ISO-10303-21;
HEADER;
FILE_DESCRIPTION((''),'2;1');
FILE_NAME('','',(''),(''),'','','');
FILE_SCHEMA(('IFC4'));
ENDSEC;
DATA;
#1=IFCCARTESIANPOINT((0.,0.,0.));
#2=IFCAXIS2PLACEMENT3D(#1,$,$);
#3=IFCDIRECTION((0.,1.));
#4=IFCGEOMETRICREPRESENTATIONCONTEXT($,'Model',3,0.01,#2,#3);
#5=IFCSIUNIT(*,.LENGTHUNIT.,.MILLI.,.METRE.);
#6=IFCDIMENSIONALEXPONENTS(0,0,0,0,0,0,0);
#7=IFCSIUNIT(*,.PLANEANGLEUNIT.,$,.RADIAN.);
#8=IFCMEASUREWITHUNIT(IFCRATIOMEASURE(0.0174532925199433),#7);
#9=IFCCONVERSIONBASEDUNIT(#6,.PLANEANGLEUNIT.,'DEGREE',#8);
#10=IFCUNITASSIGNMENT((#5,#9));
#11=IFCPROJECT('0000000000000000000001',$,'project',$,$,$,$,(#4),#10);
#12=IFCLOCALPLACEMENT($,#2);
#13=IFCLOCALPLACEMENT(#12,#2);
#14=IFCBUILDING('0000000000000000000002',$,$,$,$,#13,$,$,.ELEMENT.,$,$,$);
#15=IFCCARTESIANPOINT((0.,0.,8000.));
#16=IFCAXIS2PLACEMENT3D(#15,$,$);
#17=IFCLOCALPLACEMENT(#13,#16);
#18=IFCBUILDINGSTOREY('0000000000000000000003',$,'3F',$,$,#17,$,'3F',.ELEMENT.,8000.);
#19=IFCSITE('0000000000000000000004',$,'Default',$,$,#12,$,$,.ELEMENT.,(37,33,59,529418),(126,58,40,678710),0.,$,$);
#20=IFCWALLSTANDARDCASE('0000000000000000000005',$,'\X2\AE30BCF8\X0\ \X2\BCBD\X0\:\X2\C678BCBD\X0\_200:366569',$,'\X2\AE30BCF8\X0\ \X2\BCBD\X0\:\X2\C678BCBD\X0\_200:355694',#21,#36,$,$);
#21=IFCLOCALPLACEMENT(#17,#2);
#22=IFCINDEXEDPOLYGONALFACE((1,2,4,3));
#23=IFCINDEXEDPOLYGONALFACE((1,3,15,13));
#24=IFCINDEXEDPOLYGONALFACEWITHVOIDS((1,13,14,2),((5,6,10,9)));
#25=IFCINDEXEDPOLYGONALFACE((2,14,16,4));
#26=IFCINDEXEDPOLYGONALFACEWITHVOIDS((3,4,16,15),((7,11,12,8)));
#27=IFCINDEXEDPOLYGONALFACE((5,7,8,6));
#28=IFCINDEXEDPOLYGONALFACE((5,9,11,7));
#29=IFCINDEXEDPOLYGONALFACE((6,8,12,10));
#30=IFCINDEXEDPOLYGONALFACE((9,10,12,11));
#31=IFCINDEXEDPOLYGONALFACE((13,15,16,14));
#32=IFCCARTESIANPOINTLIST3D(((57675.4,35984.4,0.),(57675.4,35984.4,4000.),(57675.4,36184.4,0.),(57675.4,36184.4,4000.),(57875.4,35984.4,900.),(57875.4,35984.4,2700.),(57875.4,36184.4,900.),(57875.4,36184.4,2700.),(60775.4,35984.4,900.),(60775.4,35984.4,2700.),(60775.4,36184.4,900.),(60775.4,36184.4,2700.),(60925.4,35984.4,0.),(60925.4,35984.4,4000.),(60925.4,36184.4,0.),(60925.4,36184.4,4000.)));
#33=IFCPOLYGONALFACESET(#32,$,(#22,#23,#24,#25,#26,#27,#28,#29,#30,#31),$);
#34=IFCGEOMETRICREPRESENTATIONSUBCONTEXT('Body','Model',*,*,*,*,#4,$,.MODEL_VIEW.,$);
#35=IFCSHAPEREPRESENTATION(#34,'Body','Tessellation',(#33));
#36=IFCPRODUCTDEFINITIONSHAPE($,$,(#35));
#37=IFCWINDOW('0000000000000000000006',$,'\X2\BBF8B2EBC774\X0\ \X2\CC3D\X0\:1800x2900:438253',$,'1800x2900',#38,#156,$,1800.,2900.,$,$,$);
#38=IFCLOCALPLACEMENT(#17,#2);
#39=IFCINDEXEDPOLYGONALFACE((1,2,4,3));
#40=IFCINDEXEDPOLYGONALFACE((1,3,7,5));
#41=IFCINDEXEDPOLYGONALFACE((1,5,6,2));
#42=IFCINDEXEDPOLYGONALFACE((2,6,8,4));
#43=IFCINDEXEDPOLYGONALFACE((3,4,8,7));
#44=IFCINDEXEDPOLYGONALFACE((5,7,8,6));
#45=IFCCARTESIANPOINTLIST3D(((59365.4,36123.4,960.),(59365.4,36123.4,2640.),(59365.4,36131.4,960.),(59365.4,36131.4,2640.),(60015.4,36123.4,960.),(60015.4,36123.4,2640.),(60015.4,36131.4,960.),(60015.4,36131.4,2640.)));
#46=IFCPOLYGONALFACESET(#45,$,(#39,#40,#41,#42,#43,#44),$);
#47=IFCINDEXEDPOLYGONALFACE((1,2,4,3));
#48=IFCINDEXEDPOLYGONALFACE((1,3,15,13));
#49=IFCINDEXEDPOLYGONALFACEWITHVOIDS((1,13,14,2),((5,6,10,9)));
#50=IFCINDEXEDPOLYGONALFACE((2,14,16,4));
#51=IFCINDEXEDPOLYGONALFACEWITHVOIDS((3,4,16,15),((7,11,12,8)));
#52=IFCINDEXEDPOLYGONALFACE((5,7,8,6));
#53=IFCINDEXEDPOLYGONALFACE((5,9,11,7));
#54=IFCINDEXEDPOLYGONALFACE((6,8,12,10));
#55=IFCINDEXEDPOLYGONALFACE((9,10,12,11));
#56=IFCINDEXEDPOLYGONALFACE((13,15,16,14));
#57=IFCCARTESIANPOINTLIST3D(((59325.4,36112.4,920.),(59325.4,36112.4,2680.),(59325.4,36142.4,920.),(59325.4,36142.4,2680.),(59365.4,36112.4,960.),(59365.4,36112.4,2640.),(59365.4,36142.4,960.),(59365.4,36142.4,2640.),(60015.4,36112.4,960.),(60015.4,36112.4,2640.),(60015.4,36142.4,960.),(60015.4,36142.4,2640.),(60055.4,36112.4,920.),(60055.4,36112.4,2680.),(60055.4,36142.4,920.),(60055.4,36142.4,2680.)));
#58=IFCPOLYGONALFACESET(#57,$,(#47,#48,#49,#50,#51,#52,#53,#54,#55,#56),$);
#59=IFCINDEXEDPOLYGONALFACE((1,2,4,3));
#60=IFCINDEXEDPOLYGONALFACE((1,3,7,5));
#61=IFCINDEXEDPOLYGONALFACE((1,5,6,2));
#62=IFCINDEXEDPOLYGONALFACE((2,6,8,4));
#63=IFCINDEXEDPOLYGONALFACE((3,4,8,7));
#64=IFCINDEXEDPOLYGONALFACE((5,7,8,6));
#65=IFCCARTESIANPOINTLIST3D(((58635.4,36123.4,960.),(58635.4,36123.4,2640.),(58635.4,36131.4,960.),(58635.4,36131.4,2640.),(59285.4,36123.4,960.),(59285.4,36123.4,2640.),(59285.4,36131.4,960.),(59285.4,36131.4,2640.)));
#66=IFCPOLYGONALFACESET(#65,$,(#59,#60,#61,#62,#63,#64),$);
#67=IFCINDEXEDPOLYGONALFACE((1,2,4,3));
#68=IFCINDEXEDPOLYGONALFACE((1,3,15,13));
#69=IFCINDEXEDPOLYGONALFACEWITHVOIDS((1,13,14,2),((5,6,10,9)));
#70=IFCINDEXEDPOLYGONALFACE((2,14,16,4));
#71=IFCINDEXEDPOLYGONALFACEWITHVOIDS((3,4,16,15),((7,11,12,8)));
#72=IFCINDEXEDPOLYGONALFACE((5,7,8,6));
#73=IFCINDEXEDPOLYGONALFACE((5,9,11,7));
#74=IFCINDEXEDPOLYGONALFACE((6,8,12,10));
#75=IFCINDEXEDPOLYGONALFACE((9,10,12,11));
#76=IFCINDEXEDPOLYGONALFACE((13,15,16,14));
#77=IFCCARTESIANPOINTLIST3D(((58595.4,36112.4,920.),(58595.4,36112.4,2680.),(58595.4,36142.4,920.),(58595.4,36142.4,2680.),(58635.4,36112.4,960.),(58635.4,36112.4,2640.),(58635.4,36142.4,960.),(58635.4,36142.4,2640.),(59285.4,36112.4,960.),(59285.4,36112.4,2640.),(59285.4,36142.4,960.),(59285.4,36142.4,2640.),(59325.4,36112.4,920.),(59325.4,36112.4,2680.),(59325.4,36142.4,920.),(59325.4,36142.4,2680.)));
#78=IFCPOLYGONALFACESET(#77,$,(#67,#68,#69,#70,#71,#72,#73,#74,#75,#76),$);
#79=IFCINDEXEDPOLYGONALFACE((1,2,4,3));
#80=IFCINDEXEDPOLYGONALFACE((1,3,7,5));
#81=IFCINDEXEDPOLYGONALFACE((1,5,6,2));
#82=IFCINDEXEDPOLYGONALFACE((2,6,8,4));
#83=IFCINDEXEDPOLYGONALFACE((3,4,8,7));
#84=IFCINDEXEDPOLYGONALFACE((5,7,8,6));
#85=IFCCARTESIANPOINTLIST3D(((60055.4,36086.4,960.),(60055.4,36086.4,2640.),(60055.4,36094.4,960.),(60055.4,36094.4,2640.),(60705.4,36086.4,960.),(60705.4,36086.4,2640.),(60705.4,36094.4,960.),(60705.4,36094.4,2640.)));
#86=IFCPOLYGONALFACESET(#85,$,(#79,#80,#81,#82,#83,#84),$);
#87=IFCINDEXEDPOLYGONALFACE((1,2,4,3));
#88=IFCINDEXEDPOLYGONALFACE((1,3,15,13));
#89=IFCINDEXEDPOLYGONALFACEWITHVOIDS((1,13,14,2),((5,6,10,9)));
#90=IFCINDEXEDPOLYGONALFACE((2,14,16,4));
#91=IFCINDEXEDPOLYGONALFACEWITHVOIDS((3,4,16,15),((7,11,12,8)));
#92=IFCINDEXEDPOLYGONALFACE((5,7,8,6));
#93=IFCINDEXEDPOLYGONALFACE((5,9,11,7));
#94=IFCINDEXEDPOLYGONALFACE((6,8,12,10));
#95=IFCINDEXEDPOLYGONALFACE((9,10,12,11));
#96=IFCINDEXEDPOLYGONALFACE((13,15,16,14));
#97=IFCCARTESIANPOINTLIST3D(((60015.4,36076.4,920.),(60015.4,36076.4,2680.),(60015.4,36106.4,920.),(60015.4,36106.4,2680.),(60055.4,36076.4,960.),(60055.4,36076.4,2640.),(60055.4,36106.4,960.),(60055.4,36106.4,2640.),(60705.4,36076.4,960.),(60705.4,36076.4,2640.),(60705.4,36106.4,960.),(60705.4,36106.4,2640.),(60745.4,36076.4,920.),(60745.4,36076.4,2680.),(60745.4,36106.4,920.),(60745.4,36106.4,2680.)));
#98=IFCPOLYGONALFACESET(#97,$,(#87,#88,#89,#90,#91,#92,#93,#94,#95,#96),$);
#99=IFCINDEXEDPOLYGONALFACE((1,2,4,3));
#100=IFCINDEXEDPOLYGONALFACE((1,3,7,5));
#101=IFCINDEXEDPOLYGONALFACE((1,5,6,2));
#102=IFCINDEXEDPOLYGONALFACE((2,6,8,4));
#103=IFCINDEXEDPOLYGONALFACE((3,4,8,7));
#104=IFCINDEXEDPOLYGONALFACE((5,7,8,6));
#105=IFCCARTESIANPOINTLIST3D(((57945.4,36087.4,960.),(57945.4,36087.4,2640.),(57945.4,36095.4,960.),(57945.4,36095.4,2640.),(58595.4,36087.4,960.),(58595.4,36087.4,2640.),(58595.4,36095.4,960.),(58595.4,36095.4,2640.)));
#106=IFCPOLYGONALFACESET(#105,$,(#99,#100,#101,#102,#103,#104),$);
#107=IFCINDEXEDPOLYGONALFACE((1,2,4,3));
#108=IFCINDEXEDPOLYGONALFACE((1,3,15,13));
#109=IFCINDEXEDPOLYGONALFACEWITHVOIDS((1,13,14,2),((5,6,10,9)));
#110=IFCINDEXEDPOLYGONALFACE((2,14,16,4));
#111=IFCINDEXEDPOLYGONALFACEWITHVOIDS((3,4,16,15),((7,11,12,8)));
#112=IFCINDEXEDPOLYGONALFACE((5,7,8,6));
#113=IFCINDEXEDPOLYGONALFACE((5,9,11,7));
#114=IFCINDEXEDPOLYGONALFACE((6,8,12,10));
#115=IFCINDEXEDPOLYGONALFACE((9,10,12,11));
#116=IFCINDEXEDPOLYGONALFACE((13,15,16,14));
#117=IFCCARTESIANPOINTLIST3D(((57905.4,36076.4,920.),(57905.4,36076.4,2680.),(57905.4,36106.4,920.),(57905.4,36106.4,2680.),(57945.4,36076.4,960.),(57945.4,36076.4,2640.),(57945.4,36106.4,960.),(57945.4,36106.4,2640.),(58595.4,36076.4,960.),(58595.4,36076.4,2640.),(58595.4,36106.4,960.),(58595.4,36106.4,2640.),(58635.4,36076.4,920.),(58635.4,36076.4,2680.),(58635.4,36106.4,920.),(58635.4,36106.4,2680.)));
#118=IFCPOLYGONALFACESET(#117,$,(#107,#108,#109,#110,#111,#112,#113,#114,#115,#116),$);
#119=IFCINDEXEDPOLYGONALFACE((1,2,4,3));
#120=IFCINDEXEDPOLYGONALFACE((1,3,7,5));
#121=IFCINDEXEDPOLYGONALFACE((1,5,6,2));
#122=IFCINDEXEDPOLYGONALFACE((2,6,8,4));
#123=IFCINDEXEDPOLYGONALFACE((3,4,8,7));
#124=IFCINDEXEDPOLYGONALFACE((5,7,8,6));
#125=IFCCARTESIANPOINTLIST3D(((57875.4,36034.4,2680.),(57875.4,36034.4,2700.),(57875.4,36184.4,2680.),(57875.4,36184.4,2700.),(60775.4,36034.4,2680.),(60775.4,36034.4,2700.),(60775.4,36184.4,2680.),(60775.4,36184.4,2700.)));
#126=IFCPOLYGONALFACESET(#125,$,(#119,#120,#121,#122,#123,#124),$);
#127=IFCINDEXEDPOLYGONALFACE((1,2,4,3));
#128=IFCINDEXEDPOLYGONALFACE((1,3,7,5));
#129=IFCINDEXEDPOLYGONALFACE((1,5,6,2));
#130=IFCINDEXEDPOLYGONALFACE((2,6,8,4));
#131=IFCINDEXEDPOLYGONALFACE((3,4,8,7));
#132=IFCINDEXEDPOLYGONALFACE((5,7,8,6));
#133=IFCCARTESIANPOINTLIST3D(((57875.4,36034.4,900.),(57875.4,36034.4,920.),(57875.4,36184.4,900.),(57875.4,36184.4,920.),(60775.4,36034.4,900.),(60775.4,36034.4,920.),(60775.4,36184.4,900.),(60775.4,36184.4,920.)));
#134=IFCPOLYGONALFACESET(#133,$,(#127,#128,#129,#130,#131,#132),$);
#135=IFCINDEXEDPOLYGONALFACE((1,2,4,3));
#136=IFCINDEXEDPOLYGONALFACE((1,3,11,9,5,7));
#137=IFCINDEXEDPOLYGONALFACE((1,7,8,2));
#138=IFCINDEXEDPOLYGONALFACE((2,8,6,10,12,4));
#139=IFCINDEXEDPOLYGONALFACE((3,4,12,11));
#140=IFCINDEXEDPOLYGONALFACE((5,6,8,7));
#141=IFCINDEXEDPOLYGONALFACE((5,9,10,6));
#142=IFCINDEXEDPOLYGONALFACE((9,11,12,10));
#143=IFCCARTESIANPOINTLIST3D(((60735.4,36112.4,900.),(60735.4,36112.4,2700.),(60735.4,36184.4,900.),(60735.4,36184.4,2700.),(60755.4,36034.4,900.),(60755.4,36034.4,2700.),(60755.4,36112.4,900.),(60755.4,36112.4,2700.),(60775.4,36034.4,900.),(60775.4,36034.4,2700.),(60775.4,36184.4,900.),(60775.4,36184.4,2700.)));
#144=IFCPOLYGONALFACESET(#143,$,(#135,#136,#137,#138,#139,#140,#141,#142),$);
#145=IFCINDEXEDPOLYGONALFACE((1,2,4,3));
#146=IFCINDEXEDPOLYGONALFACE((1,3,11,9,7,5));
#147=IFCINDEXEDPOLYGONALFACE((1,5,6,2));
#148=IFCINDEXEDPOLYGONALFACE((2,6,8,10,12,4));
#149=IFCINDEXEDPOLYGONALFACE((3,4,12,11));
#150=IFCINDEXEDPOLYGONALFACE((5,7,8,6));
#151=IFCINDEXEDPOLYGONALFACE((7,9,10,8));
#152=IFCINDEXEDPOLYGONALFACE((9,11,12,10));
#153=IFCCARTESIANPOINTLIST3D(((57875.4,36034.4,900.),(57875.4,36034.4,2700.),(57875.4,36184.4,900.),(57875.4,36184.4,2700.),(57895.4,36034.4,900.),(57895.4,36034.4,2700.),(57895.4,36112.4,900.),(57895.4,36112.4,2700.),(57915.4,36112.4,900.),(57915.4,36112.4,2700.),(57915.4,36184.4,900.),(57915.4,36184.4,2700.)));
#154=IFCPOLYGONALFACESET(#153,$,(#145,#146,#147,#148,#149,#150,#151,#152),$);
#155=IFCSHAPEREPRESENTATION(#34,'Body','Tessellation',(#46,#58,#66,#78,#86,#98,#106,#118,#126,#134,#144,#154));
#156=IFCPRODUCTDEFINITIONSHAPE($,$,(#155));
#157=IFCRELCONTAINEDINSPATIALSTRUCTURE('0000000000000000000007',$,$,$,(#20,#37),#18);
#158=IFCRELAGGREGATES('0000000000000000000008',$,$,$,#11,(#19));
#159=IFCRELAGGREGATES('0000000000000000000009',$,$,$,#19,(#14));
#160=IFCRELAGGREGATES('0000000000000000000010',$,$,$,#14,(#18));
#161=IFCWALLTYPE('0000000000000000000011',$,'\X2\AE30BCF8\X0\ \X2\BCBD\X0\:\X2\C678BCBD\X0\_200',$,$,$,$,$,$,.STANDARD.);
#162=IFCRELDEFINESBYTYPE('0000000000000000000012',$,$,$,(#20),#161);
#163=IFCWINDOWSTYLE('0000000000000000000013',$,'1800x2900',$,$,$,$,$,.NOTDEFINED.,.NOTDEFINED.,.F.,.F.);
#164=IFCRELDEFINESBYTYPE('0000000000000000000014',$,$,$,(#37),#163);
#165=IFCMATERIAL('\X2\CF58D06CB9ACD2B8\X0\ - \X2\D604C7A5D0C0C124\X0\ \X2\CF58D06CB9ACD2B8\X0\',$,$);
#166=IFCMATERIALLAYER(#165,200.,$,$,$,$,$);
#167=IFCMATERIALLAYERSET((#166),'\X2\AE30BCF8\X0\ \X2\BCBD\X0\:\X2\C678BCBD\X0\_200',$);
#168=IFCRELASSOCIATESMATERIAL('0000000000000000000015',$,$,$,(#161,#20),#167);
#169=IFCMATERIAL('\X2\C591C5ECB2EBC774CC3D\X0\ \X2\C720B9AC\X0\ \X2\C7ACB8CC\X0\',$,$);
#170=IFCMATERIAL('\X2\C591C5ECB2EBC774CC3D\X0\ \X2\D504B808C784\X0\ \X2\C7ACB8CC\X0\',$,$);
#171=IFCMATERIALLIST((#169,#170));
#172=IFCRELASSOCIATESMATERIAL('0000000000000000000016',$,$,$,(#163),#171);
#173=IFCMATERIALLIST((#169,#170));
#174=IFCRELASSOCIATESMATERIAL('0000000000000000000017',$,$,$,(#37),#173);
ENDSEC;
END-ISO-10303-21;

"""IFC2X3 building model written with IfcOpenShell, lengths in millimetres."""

from ifc_helpers import new_model, entity, si_unit, converted_unit, direction, frame, frame_2d, origin, origin_2d_with_axis, place, context, subcontext, project, spatial, polyline, rectangle, outline, extrude, source, transform, mapped, material, material_list, layer, layer_set, layer_usage, type_object, type_shapes, element, fill, save


model = new_model("IFC2X3")

# Units and contexts
model_context = context("Model", 3, precision=0.01, world=origin(), true_north=direction((0.0, 1.0)))
body_context = subcontext(model_context, "Body", "Model", "MODEL_VIEW")
ifc_project = project(units=[si_unit("LENGTHUNIT", "METRE", prefix="MILLI"), converted_unit("PLANEANGLEUNIT", "DEGREE", entity("IfcRatioMeasure", 0.0174532925199433), si_unit("PLANEANGLEUNIT", "RADIAN"), dimensions=[0, 0, 0, 0, 0, 0, 0])], contexts=[model_context])

# Site, building, storey
site_placement = place(None, origin())
site = spatial("IfcSite", under=ifc_project, at=site_placement, Name="Default", CompositionType="ELEMENT", RefLatitude=(37, 33, 59, 529418), RefLongitude=(126, 58, 40, 678710), RefElevation=0.0)
building_placement = place(site_placement, origin())
building = spatial("IfcBuilding", under=site, at=building_placement, CompositionType="ELEMENT")
storey_placement = place(building_placement, frame((0.0, 0.0, 8000.0)))
storey = spatial("IfcBuildingStorey", under=building, at=storey_placement, Name="3F", LongName="3F", CompositionType="ELEMENT", Elevation=8000.0)

# Wall, opening, window
ifc_material_1 = material(Name="콘크리트 - 현장타설 콘크리트")
ifc_layer_1 = layer(ifc_material_1, 200.0)
ifc_layer_set_1 = layer_set([ifc_layer_1], Name="기본 벽:외벽_200")
ifc_layer_usage_1 = layer_usage(ifc_layer_set_1, "AXIS2", "NEGATIVE", 100.0)
wall_type_1 = type_object("IfcWallType", Name="기본 벽:외벽_200", PredefinedType="STANDARD", material=ifc_layer_set_1)
wall_1_placement = place(storey_placement, frame((60925.4, 36084.4, 0.0), z_axis=(0.0, 0.0, 1.0), x_axis=(-1.0, 0.0, 0.0)))
wall_1 = element("IfcWallStandardCase", 1, at=wall_1_placement, inside=storey, type_object=wall_type_1, material=ifc_layer_usage_1, Name="기본 벽:외벽_200:366569", ObjectType="기본 벽:외벽_200:355694", context=body_context, shape_type="SweptSolid", body=[
    extrude(rectangle(XDim=3250.0, YDim=200.0, at=frame_2d((1625.0, 0.0), x_axis=(-1.0, 0.0))), origin(), (0.0, 0.0, 1.0), 4000.0),
])
opening_1_placement = place(wall_1_placement, frame((3050.0, 100.0, 900.0)))
opening_1 = element("IfcOpeningElement", 2, at=opening_1_placement, cuts=wall_1, ObjectType="Opening", context=body_context, shape_type="SweptSolid", body=[
    extrude(rectangle(XDim=1800.0, YDim=2900.0, at=frame_2d((900.0, 1450.0), x_axis=(1.0, 0.0))), frame((0.0, 0.0, 0.0), z_axis=(0.0, -1.0, 0.0), x_axis=(0.0, 0.0, 1.0)), (0.0, 0.0, 1.0), 200.0),
])
ifc_material_2 = material(Name="양여닫이창 유리 재료")
ifc_material_3 = material(Name="양여닫이창 프레임 재료")
ifc_material_list_1 = material_list([ifc_material_2, ifc_material_3])
ifc_material_list_2 = material_list([ifc_material_2, ifc_material_3])
window_style = type_object("IfcWindowStyle", Name="1800x2900", ConstructionType="NOTDEFINED", OperationType="NOTDEFINED", ParameterTakesPrecedence=False, Sizeable=False, material=ifc_material_list_2)
shared_shape_1 = source(origin(), body_context, "Body", "SweptSolid", [
    extrude(rectangle(XDim=8.0, YDim=650.0, at=frame_2d((0.0, 0.0), x_axis=(1.0, 0.0))), frame((1815.0, 143.0, 60.0), z_axis=(0.0, 0.0, 1.0), x_axis=(0.0, 1.0, 0.0)), (0.0, 0.0, 1.0), 1680.0),
    extrude(outline(polyline([(-880.0, -365.0), (880.0, -365.0), (880.0, 365.0), (-880.0, 365.0), (-880.0, -365.0)]), holes=[polyline([(840.0, -325.0), (-840.0, -325.0), (-840.0, 325.0), (840.0, 325.0), (840.0, -325.0)])]), frame((1815.0, 128.0, 900.0), z_axis=(0.0, 1.0, 0.0), x_axis=(0.0, 0.0, -1.0)), (0.0, 0.0, 1.0), 30.0),
    extrude(rectangle(XDim=8.0, YDim=650.0, at=frame_2d((0.0, 0.0), x_axis=(1.0, 0.0))), frame((1085.0, 143.0, 60.0), z_axis=(0.0, 0.0, 1.0), x_axis=(0.0, 1.0, 0.0)), (0.0, 0.0, 1.0), 1680.0),
    extrude(outline(polyline([(-880.0, -365.0), (880.0, -365.0), (880.0, 365.0), (-880.0, 365.0), (-880.0, -365.0)]), holes=[polyline([(840.0, -325.0), (-840.0, -325.0), (-840.0, 325.0), (840.0, 325.0), (840.0, -325.0)])]), frame((1085.0, 128.0, 900.0), z_axis=(0.0, 1.0, 0.0), x_axis=(0.0, 0.0, -1.0)), (0.0, 0.0, 1.0), 30.0),
    extrude(rectangle(XDim=8.0, YDim=650.0, at=frame_2d((0.0, 0.0), x_axis=(1.0, 0.0))), frame((2505.0, 106.0, 60.0), z_axis=(0.0, 0.0, 1.0), x_axis=(0.0, 1.0, 0.0)), (0.0, 0.0, 1.0), 1680.0),
    extrude(outline(polyline([(-880.0, -365.0), (880.0, -365.0), (880.0, 365.0), (-880.0, 365.0), (-880.0, -365.0)]), holes=[polyline([(840.0, -325.0), (-840.0, -325.0), (-840.0, 325.0), (840.0, 325.0), (840.0, -325.0)])]), frame((2505.0, 92.0, 900.0), z_axis=(0.0, 1.0, 0.0), x_axis=(0.0, 0.0, -1.0)), (0.0, 0.0, 1.0), 30.0),
    extrude(rectangle(XDim=8.0, YDim=650.0, at=origin_2d_with_axis()), frame((395.0, 107.0, 60.0), z_axis=(0.0, 0.0, 1.0), x_axis=(0.0, 1.0, 0.0)), (0.0, 0.0, 1.0), 1680.0),
    extrude(outline(polyline([(-880.0, -365.0), (880.0, -365.0), (880.0, 365.0), (-880.0, 365.0), (-880.0, -365.0)]), holes=[polyline([(840.0, -325.0), (-840.0, -325.0), (-840.0, 325.0), (840.0, 325.0), (840.0, -325.0)])]), frame((395.0, 92.0, 900.0), z_axis=(0.0, 1.0, 0.0), x_axis=(0.0, 0.0, -1.0)), (0.0, 0.0, 1.0), 30.0),
    extrude(rectangle(XDim=2900.0, YDim=150.0, at=origin_2d_with_axis()), frame((1450.0, 125.0, 1780.0), z_axis=(0.0, 0.0, 1.0), x_axis=(-1.0, 0.0, 0.0)), (0.0, 0.0, 1.0), 20.0),
    extrude(rectangle(XDim=2900.0, YDim=150.0, at=origin_2d_with_axis()), frame((1450.0, 125.0, 0.0), z_axis=(0.0, 0.0, 1.0), x_axis=(-1.0, 0.0, 0.0)), (0.0, 0.0, 1.0), 20.0),
    extrude(outline(polyline([(-74.0, -20.0), (-2.0, -20.0), (-2.0, 0.0), (76.0, 0.0), (76.0, 20.0), (-74.0, 20.0), (-74.0, -20.0)])), frame((2880.0, 126.0, 0.0), z_axis=(0.0, 0.0, 1.0), x_axis=(0.0, -1.0, 0.0)), (0.0, 0.0, 1.0), 1800.0),
    extrude(outline(polyline([(-20.0, -74.0), (20.0, -74.0), (20.0, 76.0), (0.0, 76.0), (0.0, -2.0), (-20.0, -2.0), (-20.0, -74.0)])), frame((20.0, 126.0, 0.0), z_axis=(0.0, 0.0, 1.0), x_axis=(-1.0, 0.0, 0.0)), (0.0, 0.0, 1.0), 1800.0),
])
type_shapes(window_style, [shared_shape_1])
window_1_placement = place(opening_1_placement, frame((0.0, 0.0, 0.0), z_axis=(0.0, 0.0, 1.0), x_axis=(-1.0, 0.0, 0.0)))
window_1 = element("IfcWindow", 3, at=window_1_placement, inside=storey, type_object=window_style, material=ifc_material_list_1, Name="미닫이 창:1800x2900:438253", ObjectType="1800x2900", OverallHeight=1800.0, OverallWidth=2900.0, context=body_context, shape_type="MappedRepresentation", body=[
    mapped(shared_shape_1, transform((0.0, 0.0, 0.0), scale=1.0)),
])
fill(opening_1, window_1)

save(model, "model.ifc")
